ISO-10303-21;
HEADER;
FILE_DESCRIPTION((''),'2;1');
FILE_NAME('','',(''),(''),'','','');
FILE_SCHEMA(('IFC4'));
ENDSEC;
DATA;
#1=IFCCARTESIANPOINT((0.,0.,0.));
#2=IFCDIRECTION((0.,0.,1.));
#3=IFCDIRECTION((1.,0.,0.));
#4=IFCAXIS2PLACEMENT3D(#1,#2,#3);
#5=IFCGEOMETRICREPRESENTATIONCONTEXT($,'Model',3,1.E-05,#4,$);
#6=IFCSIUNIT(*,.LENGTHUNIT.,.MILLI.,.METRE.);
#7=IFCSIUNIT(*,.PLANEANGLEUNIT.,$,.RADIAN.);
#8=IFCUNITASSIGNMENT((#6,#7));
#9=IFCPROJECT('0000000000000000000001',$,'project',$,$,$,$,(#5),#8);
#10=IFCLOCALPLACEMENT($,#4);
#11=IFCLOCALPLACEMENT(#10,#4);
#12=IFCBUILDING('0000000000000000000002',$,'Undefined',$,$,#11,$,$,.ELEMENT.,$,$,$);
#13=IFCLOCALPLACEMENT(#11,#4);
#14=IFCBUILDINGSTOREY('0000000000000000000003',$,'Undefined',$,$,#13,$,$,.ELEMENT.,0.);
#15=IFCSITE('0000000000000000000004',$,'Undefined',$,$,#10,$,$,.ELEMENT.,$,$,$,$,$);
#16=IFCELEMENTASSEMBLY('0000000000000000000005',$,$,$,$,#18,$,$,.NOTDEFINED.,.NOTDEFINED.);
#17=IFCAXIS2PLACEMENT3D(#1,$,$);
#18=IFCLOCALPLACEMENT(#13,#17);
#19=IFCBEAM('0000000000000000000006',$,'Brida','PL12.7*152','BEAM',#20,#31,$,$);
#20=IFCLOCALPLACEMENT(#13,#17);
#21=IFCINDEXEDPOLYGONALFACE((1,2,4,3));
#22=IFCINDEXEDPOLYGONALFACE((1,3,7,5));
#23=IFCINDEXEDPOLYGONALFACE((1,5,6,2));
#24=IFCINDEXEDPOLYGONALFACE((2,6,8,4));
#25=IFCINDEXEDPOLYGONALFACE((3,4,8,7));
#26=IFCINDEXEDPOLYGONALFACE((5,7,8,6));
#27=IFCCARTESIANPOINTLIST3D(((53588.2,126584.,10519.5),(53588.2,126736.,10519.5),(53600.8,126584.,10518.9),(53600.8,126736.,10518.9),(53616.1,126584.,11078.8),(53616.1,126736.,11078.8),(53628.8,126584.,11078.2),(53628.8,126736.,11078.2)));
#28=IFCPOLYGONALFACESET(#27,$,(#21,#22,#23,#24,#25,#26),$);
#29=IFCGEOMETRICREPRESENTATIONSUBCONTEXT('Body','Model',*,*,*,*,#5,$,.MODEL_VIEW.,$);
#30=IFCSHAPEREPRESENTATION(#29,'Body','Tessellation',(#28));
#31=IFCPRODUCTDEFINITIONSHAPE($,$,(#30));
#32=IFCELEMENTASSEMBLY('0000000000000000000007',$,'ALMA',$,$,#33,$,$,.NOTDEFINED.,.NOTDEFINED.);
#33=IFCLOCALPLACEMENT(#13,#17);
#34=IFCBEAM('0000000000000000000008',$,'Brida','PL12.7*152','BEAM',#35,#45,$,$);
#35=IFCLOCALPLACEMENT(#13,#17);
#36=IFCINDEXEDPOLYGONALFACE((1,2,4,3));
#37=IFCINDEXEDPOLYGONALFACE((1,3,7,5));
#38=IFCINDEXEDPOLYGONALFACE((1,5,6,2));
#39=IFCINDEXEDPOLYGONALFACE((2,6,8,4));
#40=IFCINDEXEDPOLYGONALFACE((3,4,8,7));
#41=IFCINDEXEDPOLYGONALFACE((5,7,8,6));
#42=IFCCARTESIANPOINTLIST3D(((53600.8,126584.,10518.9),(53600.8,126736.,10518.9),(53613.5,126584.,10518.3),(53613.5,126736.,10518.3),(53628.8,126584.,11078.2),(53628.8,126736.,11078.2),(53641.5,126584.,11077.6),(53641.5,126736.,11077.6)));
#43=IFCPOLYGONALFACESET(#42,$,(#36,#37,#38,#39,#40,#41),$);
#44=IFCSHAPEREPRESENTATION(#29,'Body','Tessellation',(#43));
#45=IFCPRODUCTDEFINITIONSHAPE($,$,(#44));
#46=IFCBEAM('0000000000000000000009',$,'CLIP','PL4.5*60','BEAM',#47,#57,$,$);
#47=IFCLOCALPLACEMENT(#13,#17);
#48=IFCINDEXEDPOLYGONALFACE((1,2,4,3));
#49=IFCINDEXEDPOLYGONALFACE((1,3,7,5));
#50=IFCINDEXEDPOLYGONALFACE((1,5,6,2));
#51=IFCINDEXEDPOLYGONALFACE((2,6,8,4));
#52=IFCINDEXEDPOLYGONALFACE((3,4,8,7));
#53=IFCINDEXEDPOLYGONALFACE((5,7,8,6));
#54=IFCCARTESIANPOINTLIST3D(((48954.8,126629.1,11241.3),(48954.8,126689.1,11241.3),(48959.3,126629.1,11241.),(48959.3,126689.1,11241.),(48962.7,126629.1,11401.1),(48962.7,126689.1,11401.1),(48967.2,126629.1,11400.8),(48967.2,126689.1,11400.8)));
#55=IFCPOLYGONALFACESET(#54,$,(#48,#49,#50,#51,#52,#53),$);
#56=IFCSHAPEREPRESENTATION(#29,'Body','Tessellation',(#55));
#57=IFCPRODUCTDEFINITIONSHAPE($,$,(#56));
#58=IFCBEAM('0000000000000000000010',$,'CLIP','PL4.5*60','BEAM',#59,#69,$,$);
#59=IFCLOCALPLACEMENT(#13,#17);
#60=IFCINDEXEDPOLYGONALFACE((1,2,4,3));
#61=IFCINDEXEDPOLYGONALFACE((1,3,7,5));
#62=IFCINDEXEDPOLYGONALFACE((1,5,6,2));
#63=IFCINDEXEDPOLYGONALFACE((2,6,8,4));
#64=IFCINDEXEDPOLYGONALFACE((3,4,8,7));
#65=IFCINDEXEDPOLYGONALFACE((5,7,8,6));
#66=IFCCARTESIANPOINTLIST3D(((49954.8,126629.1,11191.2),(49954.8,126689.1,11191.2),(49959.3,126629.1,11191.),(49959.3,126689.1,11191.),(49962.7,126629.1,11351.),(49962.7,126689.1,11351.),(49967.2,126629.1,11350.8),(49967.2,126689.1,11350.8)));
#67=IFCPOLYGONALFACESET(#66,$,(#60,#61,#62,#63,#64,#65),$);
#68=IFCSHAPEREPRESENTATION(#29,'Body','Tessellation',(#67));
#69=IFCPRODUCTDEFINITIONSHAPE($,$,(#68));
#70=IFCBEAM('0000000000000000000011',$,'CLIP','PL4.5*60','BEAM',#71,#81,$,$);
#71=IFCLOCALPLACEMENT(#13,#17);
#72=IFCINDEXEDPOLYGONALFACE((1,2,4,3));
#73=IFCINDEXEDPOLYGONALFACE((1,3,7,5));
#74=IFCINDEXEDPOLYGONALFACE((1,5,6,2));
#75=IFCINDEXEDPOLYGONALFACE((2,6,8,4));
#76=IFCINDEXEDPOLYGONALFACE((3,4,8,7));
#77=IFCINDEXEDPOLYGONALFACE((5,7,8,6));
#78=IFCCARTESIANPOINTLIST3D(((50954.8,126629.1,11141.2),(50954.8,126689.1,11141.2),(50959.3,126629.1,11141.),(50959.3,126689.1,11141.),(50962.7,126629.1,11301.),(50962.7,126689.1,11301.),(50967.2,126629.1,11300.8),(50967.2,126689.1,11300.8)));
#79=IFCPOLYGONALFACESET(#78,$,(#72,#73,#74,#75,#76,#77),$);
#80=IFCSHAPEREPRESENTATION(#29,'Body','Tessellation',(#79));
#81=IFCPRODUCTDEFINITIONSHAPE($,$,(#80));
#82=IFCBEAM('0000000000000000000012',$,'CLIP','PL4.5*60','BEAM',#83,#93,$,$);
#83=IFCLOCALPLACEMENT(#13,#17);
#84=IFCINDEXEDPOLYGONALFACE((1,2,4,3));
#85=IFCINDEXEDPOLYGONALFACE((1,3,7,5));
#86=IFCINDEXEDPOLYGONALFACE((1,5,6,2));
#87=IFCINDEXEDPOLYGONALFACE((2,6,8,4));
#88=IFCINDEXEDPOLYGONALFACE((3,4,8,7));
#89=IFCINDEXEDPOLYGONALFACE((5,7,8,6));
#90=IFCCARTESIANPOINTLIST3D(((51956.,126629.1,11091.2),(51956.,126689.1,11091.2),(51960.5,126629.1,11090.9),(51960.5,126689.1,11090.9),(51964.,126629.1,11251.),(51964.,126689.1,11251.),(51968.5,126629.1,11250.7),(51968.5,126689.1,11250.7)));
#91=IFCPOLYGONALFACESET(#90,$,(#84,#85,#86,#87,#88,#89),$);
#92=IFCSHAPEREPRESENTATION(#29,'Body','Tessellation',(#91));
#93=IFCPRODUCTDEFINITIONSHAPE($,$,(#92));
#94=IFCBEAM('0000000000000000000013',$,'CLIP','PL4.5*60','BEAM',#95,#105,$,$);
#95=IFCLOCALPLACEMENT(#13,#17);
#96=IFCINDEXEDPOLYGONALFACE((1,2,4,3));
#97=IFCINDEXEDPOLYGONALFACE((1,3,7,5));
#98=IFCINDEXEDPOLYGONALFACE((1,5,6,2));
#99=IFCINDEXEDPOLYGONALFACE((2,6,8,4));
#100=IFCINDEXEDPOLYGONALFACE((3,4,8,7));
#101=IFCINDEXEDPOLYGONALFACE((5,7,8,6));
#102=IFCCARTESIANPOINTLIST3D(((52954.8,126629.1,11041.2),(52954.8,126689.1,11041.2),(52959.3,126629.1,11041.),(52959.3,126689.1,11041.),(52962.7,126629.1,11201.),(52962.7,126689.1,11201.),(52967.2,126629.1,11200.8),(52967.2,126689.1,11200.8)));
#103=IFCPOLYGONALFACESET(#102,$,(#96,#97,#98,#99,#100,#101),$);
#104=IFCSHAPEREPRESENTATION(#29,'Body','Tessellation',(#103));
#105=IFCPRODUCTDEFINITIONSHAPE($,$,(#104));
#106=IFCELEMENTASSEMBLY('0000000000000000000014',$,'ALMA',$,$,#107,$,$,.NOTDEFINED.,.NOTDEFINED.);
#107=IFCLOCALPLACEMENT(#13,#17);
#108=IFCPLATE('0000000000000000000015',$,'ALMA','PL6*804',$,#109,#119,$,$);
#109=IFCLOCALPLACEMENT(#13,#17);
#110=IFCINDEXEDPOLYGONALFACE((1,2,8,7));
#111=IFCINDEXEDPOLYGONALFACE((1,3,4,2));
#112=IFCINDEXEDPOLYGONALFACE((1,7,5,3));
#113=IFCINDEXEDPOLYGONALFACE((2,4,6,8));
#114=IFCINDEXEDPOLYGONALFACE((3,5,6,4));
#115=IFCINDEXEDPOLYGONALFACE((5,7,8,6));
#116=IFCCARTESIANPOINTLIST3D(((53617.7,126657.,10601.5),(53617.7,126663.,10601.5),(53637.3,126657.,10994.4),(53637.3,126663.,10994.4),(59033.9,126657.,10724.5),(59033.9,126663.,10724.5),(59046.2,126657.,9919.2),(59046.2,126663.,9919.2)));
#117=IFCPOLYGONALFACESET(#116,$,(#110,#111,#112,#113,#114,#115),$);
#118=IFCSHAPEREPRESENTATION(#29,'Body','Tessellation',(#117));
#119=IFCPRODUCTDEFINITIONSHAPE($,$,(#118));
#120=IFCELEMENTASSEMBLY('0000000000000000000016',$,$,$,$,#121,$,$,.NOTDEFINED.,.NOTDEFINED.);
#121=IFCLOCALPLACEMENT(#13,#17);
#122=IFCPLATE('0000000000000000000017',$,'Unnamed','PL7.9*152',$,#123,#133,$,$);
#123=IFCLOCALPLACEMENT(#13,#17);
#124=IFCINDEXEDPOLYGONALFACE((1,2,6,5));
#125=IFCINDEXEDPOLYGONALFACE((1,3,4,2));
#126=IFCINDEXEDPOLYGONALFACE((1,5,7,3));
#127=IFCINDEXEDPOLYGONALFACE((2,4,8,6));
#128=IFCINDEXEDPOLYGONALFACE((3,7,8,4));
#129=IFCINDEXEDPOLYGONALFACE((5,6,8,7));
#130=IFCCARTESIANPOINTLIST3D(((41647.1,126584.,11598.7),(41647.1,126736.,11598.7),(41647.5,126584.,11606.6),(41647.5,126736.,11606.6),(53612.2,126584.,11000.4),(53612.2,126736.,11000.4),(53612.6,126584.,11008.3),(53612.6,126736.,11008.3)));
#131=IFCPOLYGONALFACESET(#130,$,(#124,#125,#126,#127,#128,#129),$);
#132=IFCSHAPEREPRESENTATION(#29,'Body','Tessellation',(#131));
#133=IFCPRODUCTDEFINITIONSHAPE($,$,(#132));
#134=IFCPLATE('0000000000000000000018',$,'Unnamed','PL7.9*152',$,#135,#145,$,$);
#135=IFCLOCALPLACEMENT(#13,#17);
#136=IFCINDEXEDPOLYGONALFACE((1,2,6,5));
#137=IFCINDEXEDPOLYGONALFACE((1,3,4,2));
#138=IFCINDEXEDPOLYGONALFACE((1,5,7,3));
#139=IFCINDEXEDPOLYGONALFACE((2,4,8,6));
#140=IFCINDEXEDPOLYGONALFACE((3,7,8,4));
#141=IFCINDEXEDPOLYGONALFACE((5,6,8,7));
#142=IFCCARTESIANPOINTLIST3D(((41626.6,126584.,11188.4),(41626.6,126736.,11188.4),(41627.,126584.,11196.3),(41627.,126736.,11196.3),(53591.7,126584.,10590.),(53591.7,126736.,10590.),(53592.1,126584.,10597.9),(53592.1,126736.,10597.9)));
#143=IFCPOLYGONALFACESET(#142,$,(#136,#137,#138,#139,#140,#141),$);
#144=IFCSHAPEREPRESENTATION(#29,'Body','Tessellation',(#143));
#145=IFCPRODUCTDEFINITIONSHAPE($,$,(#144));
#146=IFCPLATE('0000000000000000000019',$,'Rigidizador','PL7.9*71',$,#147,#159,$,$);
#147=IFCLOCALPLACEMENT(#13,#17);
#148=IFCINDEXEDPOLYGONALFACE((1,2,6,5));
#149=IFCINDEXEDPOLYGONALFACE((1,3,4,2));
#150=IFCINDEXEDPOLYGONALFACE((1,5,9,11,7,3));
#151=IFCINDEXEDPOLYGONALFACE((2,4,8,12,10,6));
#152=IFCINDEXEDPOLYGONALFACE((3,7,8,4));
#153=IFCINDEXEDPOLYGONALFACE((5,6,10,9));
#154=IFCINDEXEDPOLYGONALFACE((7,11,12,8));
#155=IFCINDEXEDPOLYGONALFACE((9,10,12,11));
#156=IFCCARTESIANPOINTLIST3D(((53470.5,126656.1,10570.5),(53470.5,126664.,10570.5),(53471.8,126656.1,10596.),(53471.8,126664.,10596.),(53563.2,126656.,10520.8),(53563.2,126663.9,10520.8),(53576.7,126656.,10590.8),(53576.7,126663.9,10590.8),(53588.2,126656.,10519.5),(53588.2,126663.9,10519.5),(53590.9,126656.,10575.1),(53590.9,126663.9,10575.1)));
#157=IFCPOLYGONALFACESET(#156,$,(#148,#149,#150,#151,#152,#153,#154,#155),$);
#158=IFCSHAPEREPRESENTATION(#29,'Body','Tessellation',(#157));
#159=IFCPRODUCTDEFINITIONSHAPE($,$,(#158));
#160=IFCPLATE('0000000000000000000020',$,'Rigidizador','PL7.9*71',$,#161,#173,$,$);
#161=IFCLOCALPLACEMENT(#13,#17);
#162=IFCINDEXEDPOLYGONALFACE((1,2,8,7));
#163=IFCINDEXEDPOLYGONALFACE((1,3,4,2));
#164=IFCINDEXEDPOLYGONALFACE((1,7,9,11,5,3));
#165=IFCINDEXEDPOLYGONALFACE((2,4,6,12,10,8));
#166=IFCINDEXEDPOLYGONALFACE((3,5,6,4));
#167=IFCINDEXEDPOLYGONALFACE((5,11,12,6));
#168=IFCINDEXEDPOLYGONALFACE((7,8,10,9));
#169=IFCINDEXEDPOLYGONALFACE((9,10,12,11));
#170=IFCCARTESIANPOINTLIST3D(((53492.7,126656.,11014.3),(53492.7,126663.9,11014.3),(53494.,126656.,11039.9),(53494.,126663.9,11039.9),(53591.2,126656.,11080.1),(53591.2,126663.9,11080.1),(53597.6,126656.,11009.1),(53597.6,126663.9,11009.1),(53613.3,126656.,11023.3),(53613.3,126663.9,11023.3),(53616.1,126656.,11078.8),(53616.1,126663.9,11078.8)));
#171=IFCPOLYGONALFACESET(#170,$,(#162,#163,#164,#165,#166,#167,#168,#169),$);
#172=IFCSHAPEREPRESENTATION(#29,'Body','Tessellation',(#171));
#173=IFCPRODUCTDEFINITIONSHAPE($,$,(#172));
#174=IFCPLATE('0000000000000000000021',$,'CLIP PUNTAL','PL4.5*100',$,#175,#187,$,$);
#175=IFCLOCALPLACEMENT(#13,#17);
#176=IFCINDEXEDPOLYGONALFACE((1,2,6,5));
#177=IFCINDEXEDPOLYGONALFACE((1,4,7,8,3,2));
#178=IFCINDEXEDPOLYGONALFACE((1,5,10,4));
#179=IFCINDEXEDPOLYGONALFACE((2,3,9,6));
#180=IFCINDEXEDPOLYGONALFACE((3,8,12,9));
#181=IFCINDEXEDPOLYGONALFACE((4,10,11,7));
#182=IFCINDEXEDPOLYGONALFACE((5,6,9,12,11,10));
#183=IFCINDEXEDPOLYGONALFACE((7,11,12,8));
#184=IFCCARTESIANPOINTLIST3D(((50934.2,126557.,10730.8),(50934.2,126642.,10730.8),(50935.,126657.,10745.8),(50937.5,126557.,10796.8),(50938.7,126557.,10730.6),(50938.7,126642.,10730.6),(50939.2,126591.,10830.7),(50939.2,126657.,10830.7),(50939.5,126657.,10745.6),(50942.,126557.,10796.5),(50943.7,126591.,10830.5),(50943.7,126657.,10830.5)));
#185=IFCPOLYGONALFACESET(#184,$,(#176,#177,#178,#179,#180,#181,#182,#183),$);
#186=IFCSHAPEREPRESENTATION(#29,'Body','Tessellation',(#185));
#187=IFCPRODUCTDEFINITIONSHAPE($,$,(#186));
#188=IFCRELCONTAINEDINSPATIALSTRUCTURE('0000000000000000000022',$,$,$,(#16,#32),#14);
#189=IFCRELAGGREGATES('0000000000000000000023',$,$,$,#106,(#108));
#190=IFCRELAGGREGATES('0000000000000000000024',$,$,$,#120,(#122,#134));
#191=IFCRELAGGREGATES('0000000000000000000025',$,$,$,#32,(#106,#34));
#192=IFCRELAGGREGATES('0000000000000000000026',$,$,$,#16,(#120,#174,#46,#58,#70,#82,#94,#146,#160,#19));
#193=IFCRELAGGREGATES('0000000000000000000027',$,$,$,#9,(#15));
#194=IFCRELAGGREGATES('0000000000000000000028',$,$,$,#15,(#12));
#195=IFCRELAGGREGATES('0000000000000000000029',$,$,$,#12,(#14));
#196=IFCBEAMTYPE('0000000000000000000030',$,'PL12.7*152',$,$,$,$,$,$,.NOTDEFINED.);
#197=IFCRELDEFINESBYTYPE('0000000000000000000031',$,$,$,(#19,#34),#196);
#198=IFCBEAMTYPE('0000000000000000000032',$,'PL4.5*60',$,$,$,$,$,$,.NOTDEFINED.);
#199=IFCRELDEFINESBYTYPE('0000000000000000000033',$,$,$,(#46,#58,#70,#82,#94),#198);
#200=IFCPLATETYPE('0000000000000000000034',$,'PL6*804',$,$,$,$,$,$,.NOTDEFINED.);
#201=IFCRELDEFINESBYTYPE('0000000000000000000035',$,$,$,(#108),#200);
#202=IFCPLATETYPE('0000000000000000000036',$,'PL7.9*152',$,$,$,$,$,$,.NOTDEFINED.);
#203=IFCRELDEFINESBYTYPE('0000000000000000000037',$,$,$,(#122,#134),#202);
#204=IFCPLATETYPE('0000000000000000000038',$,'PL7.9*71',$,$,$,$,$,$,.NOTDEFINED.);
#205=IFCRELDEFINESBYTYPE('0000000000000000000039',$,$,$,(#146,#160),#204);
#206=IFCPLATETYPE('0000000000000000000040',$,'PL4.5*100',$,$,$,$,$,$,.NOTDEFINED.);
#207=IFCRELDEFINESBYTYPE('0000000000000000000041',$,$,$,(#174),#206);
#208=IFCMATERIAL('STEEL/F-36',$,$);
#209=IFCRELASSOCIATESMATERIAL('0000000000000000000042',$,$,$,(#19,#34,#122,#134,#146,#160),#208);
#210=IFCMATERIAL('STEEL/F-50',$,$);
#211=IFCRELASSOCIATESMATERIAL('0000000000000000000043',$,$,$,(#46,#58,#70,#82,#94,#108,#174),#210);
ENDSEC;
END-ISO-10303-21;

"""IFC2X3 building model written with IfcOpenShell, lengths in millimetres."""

from ifc_helpers import new_model, si_unit, frame, origin_with_axes, origin_2d_with_axis, place, context, subcontext, project, spatial, polyline, rectangle, outline, extrude, material, type_object, element, aggregate, save


model = new_model("IFC2X3")

# Units and contexts
model_context = context("Model", 3, precision=1e-05, world=origin_with_axes())
body_context = subcontext(model_context, "Body", "Model", "MODEL_VIEW")
ifc_project = project(units=[si_unit("LENGTHUNIT", "METRE", prefix="MILLI"), si_unit("PLANEANGLEUNIT", "RADIAN")], contexts=[model_context])

# Site, building, storey
site_placement = place(None, origin_with_axes())
site = spatial("IfcSite", under=ifc_project, at=site_placement, Name="Undefined", CompositionType="ELEMENT")
building_placement = place(site_placement, origin_with_axes())
building = spatial("IfcBuilding", under=site, at=building_placement, Name="Undefined", CompositionType="ELEMENT")
storey_placement = place(building_placement, origin_with_axes())
storey = spatial("IfcBuildingStorey", under=building, at=storey_placement, Name="Undefined", CompositionType="ELEMENT", Elevation=0.0)

# Element assemblies, beams
assembly_1_placement = place(storey_placement, origin_with_axes())
assembly_1 = element("IfcElementAssembly", 1, at=assembly_1_placement, inside=storey, AssemblyPlace="NOTDEFINED", PredefinedType="NOTDEFINED")
ifc_material_1 = material(Name="STEEL/F-36")
beam_type_1 = type_object("IfcBeamType", Name="PL12.7*152", PredefinedType="NOTDEFINED")
beam_1_placement = place(assembly_1_placement, frame((53622.5, 126660.0, 11078.5), z_axis=(0.0, 1.0, 0.0), x_axis=(-0.049943, 0.0, -0.998752)))
beam_1 = element("IfcBeam", 2, at=beam_1_placement, type_object=beam_type_1, material=ifc_material_1, Name="Brida", Description="PL12.7*152", ObjectType="BEAM", context=body_context, shape_type="SweptSolid", body=[
    extrude(rectangle(XDim=12.7, YDim=152.0, at=origin_2d_with_axis()), frame((560.0, 0.0, 0.0), z_axis=(-1.0, 0.0, 0.0), x_axis=(0.0, -1.0, 0.0)), (0.0, 0.0, 1.0), 560.0),
])
assembly_2_placement = place(storey_placement, origin_with_axes())
assembly_2 = element("IfcElementAssembly", 3, at=assembly_2_placement, inside=storey, Name="ALMA", AssemblyPlace="NOTDEFINED", PredefinedType="NOTDEFINED")
beam_2_placement = place(assembly_2_placement, frame((53635.1, 126660.0, 11077.9), z_axis=(0.0, 1.0, 0.0), x_axis=(-0.049943, 0.0, -0.998752)))
beam_2 = element("IfcBeam", 4, at=beam_2_placement, type_object=beam_type_1, material=ifc_material_1, Name="Brida", Description="PL12.7*152", ObjectType="BEAM", context=body_context, shape_type="SweptSolid", body=[
    extrude(rectangle(XDim=12.7, YDim=152.0, at=origin_2d_with_axis()), frame((560.0, 0.0, 0.0), z_axis=(-1.0, 0.0, 0.0), x_axis=(0.0, -1.0, 0.0)), (0.0, 0.0, 1.0), 560.0),
])

# Beams
ifc_material_2 = material(Name="STEEL/F-50")
beam_type_2 = type_object("IfcBeamType", Name="PL4.5*60", PredefinedType="NOTDEFINED")
beam_3_placement = place(assembly_1_placement, frame((48965.0, 126659.1, 11400.9), z_axis=(0.0, 1.0, 0.0), x_axis=(-0.049943, 0.0, -0.998752)))
beam_3 = element("IfcBeam", 5, at=beam_3_placement, type_object=beam_type_2, material=ifc_material_2, Name="CLIP", Description="PL4.5*60", ObjectType="BEAM", context=body_context, shape_type="SweptSolid", body=[
    extrude(rectangle(XDim=4.5, YDim=60.0, at=origin_2d_with_axis()), frame((160.0, 0.0, 0.0), z_axis=(-1.0, 0.0, 0.0), x_axis=(0.0, -1.0, 0.0)), (0.0, 0.0, 1.0), 160.0),
])
beam_4_placement = place(assembly_1_placement, frame((49965.0, 126659.1, 11350.9), z_axis=(0.0, 1.0, 0.0), x_axis=(-0.049943, 0.0, -0.998752)))
beam_4 = element("IfcBeam", 6, at=beam_4_placement, type_object=beam_type_2, material=ifc_material_2, Name="CLIP", Description="PL4.5*60", ObjectType="BEAM", context=body_context, shape_type="SweptSolid", body=[
    extrude(rectangle(XDim=4.5, YDim=60.0, at=origin_2d_with_axis()), frame((160.0, 0.0, 0.0), z_axis=(-1.0, 0.0, 0.0), x_axis=(0.0, -1.0, 0.0)), (0.0, 0.0, 1.0), 160.0),
])
beam_5_placement = place(assembly_1_placement, frame((50965.0, 126659.1, 11300.9), z_axis=(0.0, 1.0, 0.0), x_axis=(-0.049943, 0.0, -0.998752)))
beam_5 = element("IfcBeam", 7, at=beam_5_placement, type_object=beam_type_2, material=ifc_material_2, Name="CLIP", Description="PL4.5*60", ObjectType="BEAM", context=body_context, shape_type="SweptSolid", body=[
    extrude(rectangle(XDim=4.5, YDim=60.0, at=origin_2d_with_axis()), frame((160.0, 0.0, 0.0), z_axis=(-1.0, 0.0, 0.0), x_axis=(0.0, -1.0, 0.0)), (0.0, 0.0, 1.0), 160.0),
])
beam_6_placement = place(assembly_1_placement, frame((51966.2, 126659.1, 11250.9), z_axis=(0.0, 1.0, 0.0), x_axis=(-0.049943, 0.0, -0.998752)))
beam_6 = element("IfcBeam", 8, at=beam_6_placement, type_object=beam_type_2, material=ifc_material_2, Name="CLIP", Description="PL4.5*60", ObjectType="BEAM", context=body_context, shape_type="SweptSolid", body=[
    extrude(rectangle(XDim=4.5, YDim=60.0, at=origin_2d_with_axis()), frame((160.0, 0.0, 0.0), z_axis=(-1.0, 0.0, 0.0), x_axis=(0.0, -1.0, 0.0)), (0.0, 0.0, 1.0), 160.0),
])
beam_7_placement = place(assembly_1_placement, frame((52965.0, 126659.1, 11200.9), z_axis=(0.0, 1.0, 0.0), x_axis=(-0.049943, 0.0, -0.998752)))
beam_7 = element("IfcBeam", 9, at=beam_7_placement, type_object=beam_type_2, material=ifc_material_2, Name="CLIP", Description="PL4.5*60", ObjectType="BEAM", context=body_context, shape_type="SweptSolid", body=[
    extrude(rectangle(XDim=4.5, YDim=60.0, at=origin_2d_with_axis()), frame((160.0, 0.0, 0.0), z_axis=(-1.0, 0.0, 0.0), x_axis=(0.0, -1.0, 0.0)), (0.0, 0.0, 1.0), 160.0),
])

# Element assembly, plate
assembly_3_placement = place(assembly_2_placement, origin_with_axes())
assembly_3 = element("IfcElementAssembly", 10, at=assembly_3_placement, Name="ALMA", AssemblyPlace="NOTDEFINED", PredefinedType="NOTDEFINED")
plate_type_1 = type_object("IfcPlateType", Name="PL6*804", PredefinedType="NOTDEFINED")
plate_1_placement = place(assembly_3_placement, frame((53637.3, 126660.0, 10994.4), z_axis=(0.0, 1.0, 0.0), x_axis=(0.998752, 0.0, -0.049943)))
plate_1 = element("IfcPlate", 11, at=plate_1_placement, type_object=plate_type_1, material=ifc_material_2, Name="ALMA", Description="PL6*804", context=body_context, shape_type="SweptSolid", body=[
    extrude(outline(polyline([(0.0, 0.0), (5403.3, 0.0), (5455.8, 803.7), (0.0, 393.4), (0.0, 0.0)])), frame((0.0, 0.0, -3.0), z_axis=(0.0, 0.0, 1.0), x_axis=(1.0, 0.0, 0.0)), (0.0, 0.0, 1.0), 6.0),
])
aggregate(assembly_3, [plate_1])

# Element assembly, plates
assembly_4_placement = place(assembly_1_placement, origin_with_axes())
assembly_4 = element("IfcElementAssembly", 12, at=assembly_4_placement, AssemblyPlace="NOTDEFINED", PredefinedType="NOTDEFINED")
plate_type_2 = type_object("IfcPlateType", Name="PL7.9*152", PredefinedType="NOTDEFINED")
plate_2_placement = place(assembly_4_placement, frame((53612.4, 126660.0, 11004.4), z_axis=(-0.049943, 0.0, -0.998752), x_axis=(-0.998752, 0.0, 0.049943)))
plate_2 = element("IfcPlate", 13, at=plate_2_placement, type_object=plate_type_2, material=ifc_material_1, Name="Unnamed", Description="PL7.9*152", context=body_context, shape_type="SweptSolid", body=[
    extrude(outline(polyline([(0.0, -76.0), (0.0, 76.0), (11980.0, 76.0), (11980.0, -76.0), (0.0, -76.0)])), frame((0.0, 0.0, -4.0), z_axis=(0.0, 0.0, 1.0), x_axis=(1.0, 0.0, 0.0)), (0.0, 0.0, 1.0), 7.9),
])
plate_3_placement = place(assembly_4_placement, frame((53591.9, 126660.0, 10594.0), z_axis=(0.049943, 0.0, 0.998752), x_axis=(-0.998752, 0.0, 0.049943)))
plate_3 = element("IfcPlate", 14, at=plate_3_placement, type_object=plate_type_2, material=ifc_material_1, Name="Unnamed", Description="PL7.9*152", context=body_context, shape_type="SweptSolid", body=[
    extrude(outline(polyline([(0.0, -76.0), (0.0, 76.0), (11980.0, 76.0), (11980.0, -76.0), (0.0, -76.0)])), frame((0.0, 0.0, -4.0), z_axis=(0.0, 0.0, 1.0), x_axis=(1.0, 0.0, 0.0)), (0.0, 0.0, 1.0), 7.9),
])
aggregate(assembly_4, [plate_2, plate_3])

# Plates
plate_type_3 = type_object("IfcPlateType", Name="PL7.9*71", PredefinedType="NOTDEFINED")
plate_4_placement = place(assembly_1_placement, frame((53588.2, 126660.0, 10519.5), z_axis=(0.0, -1.0, 0.0), x_axis=(0.049943, 0.0, 0.998752)))
plate_4 = element("IfcPlate", 15, at=plate_4_placement, type_object=plate_type_3, material=ifc_material_1, Name="Rigidizador", Description="PL7.9*71", context=body_context, shape_type="SweptSolid", body=[
    extrude(outline(polyline([(0.0, 0.0), (55.6, 0.0), (70.6, 15.0), (70.6, 120.0), (45.0, 120.0), (0.0, 25.0), (0.0, 0.0)])), frame((0.0, 0.0, -4.0), z_axis=(0.0, 0.0, 1.0), x_axis=(1.0, 0.0, 0.0)), (0.0, 0.0, 1.0), 7.9),
])
plate_5_placement = place(assembly_1_placement, frame((53616.1, 126660.0, 11078.8), z_axis=(0.0, 1.0, 0.0), x_axis=(-0.049943, 0.0, -0.998752)))
plate_5 = element("IfcPlate", 16, at=plate_5_placement, type_object=plate_type_3, material=ifc_material_1, Name="Rigidizador", Description="PL7.9*71", context=body_context, shape_type="SweptSolid", body=[
    extrude(outline(polyline([(0.0, 0.0), (55.6, 0.0), (70.6, 15.0), (70.6, 120.0), (45.0, 120.0), (0.0, 25.0), (0.0, 0.0)])), frame((0.0, 0.0, -4.0), z_axis=(0.0, 0.0, 1.0), x_axis=(1.0, 0.0, 0.0)), (0.0, 0.0, 1.0), 7.9),
])
plate_type_4 = type_object("IfcPlateType", Name="PL4.5*100", PredefinedType="NOTDEFINED")
plate_6_placement = place(assembly_1_placement, frame((50941.5, 126657.0, 10830.6), z_axis=(0.998754, 0.0, -0.049896), x_axis=(0.0, -1.0, 0.0)))
plate_6 = element("IfcPlate", 17, at=plate_6_placement, type_object=plate_type_4, material=ifc_material_2, Name="CLIP PUNTAL", Description="PL4.5*100", context=body_context, shape_type="SweptSolid", body=[
    extrude(outline(polyline([(0.0, 0.0), (66.0, 0.0), (100.0, 34.0), (100.0, 100.0), (15.0, 100.0), (0.0, 85.0), (0.0, 0.0)])), frame((0.0, 0.0, -2.2), z_axis=(0.0, 0.0, 1.0), x_axis=(1.0, 0.0, 0.0)), (0.0, 0.0, 1.0), 4.5),
])

aggregate(assembly_2, [assembly_3, beam_2])

aggregate(assembly_1, [assembly_4, plate_6, beam_3, beam_4, beam_5, beam_6, beam_7, plate_4, plate_5, beam_1])

save(model, "model.ifc")
